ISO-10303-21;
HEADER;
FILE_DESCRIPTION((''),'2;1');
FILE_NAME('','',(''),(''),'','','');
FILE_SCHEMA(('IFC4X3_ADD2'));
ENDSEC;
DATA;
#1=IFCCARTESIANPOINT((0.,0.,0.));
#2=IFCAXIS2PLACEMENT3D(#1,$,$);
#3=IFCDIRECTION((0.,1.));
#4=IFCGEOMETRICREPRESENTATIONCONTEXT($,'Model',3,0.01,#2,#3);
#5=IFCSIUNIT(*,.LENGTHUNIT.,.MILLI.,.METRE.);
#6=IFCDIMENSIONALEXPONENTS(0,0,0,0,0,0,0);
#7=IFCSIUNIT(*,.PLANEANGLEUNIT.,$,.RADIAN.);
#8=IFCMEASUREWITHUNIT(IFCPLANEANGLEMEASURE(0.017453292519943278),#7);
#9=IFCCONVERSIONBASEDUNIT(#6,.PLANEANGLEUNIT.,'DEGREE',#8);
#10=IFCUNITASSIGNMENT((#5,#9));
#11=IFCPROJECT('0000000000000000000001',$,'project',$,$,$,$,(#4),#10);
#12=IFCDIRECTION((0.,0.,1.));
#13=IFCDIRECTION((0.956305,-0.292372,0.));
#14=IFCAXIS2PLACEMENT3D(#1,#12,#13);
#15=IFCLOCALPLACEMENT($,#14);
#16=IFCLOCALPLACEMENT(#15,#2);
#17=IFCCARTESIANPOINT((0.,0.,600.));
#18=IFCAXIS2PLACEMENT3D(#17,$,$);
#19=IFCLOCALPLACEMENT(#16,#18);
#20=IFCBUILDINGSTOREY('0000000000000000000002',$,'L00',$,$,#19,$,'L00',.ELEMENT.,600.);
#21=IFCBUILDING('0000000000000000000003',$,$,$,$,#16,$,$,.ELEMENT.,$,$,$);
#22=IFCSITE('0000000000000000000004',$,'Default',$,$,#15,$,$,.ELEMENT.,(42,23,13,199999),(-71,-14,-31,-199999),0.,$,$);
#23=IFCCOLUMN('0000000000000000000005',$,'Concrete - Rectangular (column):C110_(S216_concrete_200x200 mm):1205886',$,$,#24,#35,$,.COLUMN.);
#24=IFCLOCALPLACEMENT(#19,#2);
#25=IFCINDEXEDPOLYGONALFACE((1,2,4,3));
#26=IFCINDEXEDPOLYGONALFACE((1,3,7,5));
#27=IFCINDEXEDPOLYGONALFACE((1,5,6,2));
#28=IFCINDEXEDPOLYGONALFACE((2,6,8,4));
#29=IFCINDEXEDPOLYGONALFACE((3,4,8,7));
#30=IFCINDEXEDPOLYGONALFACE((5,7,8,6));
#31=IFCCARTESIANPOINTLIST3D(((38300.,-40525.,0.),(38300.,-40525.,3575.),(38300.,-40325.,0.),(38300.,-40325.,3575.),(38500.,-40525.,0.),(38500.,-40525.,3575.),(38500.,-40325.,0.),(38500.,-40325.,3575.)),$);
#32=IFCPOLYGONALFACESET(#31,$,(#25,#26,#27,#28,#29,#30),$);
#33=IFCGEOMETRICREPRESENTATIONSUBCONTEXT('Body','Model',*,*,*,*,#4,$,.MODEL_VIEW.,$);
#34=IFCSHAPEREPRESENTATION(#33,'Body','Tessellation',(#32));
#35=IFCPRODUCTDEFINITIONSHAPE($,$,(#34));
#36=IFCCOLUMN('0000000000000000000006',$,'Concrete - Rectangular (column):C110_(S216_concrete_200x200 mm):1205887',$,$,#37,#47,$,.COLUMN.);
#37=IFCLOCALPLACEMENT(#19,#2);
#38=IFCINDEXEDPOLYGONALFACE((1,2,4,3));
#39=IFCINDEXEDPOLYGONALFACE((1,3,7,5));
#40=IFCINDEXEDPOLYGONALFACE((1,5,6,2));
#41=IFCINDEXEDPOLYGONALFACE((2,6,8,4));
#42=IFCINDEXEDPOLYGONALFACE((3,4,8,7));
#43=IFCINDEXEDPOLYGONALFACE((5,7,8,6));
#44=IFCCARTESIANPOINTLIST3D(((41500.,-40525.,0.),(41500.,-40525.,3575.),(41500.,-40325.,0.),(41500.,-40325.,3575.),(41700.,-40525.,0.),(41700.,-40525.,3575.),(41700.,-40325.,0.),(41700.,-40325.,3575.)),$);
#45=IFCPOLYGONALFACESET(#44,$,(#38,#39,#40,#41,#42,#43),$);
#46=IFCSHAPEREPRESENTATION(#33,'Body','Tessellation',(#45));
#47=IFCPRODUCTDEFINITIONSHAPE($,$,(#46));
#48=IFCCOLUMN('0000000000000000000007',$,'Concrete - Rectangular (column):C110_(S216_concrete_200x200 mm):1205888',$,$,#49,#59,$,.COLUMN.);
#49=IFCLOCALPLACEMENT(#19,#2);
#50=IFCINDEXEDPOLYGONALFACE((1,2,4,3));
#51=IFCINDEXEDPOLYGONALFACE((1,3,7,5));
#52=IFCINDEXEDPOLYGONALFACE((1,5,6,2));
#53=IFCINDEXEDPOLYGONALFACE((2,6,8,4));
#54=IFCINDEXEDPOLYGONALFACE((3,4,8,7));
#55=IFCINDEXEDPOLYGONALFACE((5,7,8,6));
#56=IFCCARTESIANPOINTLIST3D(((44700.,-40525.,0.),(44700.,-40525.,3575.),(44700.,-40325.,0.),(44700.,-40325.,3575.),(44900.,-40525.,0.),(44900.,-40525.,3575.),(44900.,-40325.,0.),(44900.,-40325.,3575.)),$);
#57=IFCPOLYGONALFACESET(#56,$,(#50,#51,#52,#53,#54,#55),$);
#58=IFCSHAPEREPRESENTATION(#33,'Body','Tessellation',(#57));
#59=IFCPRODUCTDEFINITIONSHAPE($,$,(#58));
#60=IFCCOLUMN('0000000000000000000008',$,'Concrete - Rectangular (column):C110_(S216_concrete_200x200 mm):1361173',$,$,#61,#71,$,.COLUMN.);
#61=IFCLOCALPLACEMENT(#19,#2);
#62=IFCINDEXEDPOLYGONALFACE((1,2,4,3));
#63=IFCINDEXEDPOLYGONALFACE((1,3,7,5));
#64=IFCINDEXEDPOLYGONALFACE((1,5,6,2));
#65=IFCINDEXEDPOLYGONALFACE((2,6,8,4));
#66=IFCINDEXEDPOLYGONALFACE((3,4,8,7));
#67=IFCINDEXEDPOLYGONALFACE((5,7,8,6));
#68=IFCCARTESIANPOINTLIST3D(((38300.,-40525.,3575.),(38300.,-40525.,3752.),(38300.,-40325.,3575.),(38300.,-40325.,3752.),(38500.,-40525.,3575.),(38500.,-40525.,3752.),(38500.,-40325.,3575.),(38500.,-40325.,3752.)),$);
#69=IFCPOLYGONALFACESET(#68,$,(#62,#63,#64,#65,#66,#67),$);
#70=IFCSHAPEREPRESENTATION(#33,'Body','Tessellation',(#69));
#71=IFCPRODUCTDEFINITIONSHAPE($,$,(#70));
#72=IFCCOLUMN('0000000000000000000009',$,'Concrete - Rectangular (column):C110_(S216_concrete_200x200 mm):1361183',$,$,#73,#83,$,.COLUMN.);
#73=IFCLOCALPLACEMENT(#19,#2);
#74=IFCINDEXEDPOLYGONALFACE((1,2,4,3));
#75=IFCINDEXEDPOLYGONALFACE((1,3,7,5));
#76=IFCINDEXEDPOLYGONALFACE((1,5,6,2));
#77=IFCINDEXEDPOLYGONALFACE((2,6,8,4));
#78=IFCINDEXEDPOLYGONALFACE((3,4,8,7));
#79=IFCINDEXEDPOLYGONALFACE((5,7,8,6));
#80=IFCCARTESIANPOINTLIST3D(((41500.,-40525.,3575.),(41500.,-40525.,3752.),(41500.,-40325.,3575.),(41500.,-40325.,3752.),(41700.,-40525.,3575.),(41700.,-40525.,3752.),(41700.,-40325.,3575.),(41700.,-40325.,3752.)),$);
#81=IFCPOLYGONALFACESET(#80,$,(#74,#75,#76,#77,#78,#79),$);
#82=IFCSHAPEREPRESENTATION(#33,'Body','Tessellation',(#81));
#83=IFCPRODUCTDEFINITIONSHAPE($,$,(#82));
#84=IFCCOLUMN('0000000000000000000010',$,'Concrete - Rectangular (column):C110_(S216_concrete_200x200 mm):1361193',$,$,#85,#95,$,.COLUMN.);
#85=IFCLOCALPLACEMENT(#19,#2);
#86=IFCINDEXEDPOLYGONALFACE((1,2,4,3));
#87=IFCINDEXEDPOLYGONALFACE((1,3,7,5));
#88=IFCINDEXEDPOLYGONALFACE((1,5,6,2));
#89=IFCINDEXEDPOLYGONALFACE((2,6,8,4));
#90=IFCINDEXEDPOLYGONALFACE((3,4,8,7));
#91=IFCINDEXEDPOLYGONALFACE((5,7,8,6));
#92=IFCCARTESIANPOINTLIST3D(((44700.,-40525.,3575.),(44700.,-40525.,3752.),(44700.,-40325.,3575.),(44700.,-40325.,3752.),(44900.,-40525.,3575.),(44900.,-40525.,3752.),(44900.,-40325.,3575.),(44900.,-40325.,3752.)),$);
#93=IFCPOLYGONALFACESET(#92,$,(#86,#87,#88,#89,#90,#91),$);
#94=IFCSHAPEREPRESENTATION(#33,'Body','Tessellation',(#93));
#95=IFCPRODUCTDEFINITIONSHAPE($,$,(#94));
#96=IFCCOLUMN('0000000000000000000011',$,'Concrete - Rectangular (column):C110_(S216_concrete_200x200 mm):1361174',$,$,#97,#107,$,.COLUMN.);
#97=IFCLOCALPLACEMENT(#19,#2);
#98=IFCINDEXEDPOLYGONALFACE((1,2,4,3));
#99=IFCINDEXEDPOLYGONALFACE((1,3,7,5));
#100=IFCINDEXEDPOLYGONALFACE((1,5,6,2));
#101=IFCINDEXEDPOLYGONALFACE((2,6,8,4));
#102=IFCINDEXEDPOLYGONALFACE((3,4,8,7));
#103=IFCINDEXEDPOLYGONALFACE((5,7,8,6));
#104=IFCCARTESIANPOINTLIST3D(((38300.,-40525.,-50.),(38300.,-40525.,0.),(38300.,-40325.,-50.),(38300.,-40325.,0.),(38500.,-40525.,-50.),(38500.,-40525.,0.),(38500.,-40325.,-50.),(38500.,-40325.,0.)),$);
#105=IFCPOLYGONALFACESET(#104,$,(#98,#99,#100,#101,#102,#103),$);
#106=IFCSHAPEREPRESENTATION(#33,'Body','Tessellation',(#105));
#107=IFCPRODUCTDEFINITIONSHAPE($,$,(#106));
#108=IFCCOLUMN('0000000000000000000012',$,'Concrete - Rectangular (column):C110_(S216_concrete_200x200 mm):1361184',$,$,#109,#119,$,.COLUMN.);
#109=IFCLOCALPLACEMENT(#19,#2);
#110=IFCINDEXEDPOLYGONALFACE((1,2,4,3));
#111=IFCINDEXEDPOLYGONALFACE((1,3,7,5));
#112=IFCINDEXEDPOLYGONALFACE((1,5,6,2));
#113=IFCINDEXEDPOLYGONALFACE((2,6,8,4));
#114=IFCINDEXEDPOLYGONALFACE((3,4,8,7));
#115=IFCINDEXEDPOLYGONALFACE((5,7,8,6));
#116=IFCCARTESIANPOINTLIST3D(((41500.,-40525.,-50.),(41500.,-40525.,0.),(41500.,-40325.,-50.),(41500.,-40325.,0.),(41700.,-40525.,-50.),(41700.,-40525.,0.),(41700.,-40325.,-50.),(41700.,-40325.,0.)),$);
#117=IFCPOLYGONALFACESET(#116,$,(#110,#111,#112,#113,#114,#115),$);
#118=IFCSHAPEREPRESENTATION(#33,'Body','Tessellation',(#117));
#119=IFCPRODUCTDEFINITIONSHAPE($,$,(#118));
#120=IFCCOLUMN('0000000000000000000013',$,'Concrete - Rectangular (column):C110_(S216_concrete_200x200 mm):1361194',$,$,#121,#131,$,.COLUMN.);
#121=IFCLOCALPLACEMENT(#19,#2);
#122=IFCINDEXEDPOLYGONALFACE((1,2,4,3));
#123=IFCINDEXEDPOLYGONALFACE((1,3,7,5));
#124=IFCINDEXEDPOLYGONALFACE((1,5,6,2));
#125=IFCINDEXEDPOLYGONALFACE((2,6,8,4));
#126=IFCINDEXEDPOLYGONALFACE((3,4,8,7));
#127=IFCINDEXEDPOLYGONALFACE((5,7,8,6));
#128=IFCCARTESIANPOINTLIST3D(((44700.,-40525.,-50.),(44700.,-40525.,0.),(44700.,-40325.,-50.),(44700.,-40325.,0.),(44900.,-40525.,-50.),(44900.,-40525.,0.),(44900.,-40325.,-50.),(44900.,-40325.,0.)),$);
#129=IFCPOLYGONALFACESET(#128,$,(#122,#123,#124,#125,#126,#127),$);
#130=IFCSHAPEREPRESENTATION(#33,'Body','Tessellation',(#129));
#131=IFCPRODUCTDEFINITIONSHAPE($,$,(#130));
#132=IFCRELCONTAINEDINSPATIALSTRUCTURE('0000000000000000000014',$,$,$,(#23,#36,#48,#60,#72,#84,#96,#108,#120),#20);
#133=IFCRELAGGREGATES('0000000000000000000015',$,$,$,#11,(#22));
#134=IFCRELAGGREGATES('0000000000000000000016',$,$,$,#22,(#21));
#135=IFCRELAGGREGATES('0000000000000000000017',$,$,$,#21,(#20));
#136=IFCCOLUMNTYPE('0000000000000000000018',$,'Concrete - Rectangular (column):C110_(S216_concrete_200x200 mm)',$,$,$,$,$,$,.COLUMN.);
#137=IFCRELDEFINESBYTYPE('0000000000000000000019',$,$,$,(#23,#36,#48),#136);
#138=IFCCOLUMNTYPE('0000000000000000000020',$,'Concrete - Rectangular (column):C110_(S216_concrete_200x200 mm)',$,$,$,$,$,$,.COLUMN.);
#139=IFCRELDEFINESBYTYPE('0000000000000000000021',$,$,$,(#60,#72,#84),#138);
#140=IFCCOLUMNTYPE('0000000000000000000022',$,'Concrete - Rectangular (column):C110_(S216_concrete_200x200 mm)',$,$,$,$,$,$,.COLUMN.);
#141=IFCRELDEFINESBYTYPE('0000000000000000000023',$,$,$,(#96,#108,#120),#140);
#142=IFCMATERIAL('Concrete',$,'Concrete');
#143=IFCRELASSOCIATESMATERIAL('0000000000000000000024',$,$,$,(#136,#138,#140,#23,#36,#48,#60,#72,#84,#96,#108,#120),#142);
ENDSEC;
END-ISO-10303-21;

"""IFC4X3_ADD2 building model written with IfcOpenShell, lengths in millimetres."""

from ifc_helpers import new_model, entity, si_unit, converted_unit, direction, frame, origin, origin_2d_with_axis, place, context, subcontext, project, spatial, rectangle, extrude, source, transform, mapped, material, material_profile, profile_set, profile_usage, type_object, type_shapes, element, save


model = new_model("IFC4X3_ADD2")

# Units and contexts
model_context = context("Model", 3, precision=0.01, world=origin(), true_north=direction((0.0, 1.0)))
body_context = subcontext(model_context, "Body", "Model", "MODEL_VIEW")
ifc_project = project(units=[si_unit("LENGTHUNIT", "METRE", prefix="MILLI"), converted_unit("PLANEANGLEUNIT", "DEGREE", entity("IfcPlaneAngleMeasure", 0.017453292519943278), si_unit("PLANEANGLEUNIT", "RADIAN"), dimensions=[0, 0, 0, 0, 0, 0, 0])], contexts=[model_context])

# Site, building, storey
site_placement = place(None, frame((0.0, 0.0, 0.0), z_axis=(0.0, 0.0, 1.0), x_axis=(0.956305, -0.292372, 0.0)))
site = spatial("IfcSite", under=ifc_project, at=site_placement, Name="Default", CompositionType="ELEMENT", RefLatitude=(42, 23, 13, 199999), RefLongitude=(-71, -14, -31, -199999), RefElevation=0.0)
building_placement = place(site_placement, origin())
building = spatial("IfcBuilding", under=site, at=building_placement, CompositionType="ELEMENT")
storey_placement = place(building_placement, frame((0.0, 0.0, 600.0)))
storey = spatial("IfcBuildingStorey", under=building, at=storey_placement, Name="L00", LongName="L00", CompositionType="ELEMENT", Elevation=600.0)

# Columns
ifc_material_1 = material(Name="Concrete", Category="Concrete")
ifc_material_profile_1 = material_profile(ifc_material_1, rectangle(XDim=200.0, YDim=200.0, at=origin_2d_with_axis()), Name="C110_(S216_concrete_200x200 mm)")
ifc_profile_set_1 = profile_set([ifc_material_profile_1], Name="C110_(S216_concrete_200x200 mm)")
ifc_profile_usage_1 = profile_usage(ifc_profile_set_1)
column_type_1 = type_object("IfcColumnType", Name="Concrete - Rectangular (column):C110_(S216_concrete_200x200 mm)", PredefinedType="COLUMN", material=ifc_profile_set_1)
shared_shape_1 = source(origin(), body_context, "Body", "SweptSolid", [
    extrude(rectangle(XDim=200.0, YDim=200.0, at=origin_2d_with_axis()), frame((0.0, 0.0, 600.0), z_axis=(0.0, 0.0, 1.0), x_axis=(-1.0, 0.0, 0.0)), (0.0, 0.0, 1.0), 3575.0),
])
type_shapes(column_type_1, [shared_shape_1])
for number, where, name in (
    (1, (38400.0, -40425.0, -600.0), "Concrete - Rectangular (column):C110_(S216_concrete_200x200 mm):1205886"),
    (2, (41600.0, -40425.0, -600.0), "Concrete - Rectangular (column):C110_(S216_concrete_200x200 mm):1205887"),
    (3, (44800.0, -40425.0, -600.0), "Concrete - Rectangular (column):C110_(S216_concrete_200x200 mm):1205888"),
):
    element("IfcColumn", number, at=place(storey_placement, frame(where)), inside=storey, type_object=column_type_1, material=ifc_profile_usage_1, Name=name, PredefinedType="COLUMN", context=body_context, shape_type="MappedRepresentation", body=[
        mapped(shared_shape_1, transform((0.0, 0.0, 0.0), scale=1.0)),
    ])
column_type_2 = type_object("IfcColumnType", Name="Concrete - Rectangular (column):C110_(S216_concrete_200x200 mm)", PredefinedType="COLUMN", material=ifc_profile_set_1)
shared_shape_2 = source(origin(), body_context, "Body", "SweptSolid", [
    extrude(rectangle(XDim=200.0, YDim=200.0, at=origin_2d_with_axis()), frame((0.0, 0.0, 4175.0), z_axis=(0.0, 0.0, 1.0), x_axis=(-1.0, 0.0, 0.0)), (0.0, 0.0, 1.0), 177.0),
])
type_shapes(column_type_2, [shared_shape_2])
for number, where, name in (
    (4, (38400.0, -40425.0, -600.0), "Concrete - Rectangular (column):C110_(S216_concrete_200x200 mm):1361173"),
    (5, (41600.0, -40425.0, -600.0), "Concrete - Rectangular (column):C110_(S216_concrete_200x200 mm):1361183"),
    (6, (44800.0, -40425.0, -600.0), "Concrete - Rectangular (column):C110_(S216_concrete_200x200 mm):1361193"),
):
    element("IfcColumn", number, at=place(storey_placement, frame(where)), inside=storey, type_object=column_type_2, material=ifc_profile_usage_1, Name=name, PredefinedType="COLUMN", context=body_context, shape_type="MappedRepresentation", body=[
        mapped(shared_shape_2, transform((0.0, 0.0, 0.0), scale=1.0)),
    ])
column_type_3 = type_object("IfcColumnType", Name="Concrete - Rectangular (column):C110_(S216_concrete_200x200 mm)", PredefinedType="COLUMN", material=ifc_profile_set_1)
shared_shape_3 = source(origin(), body_context, "Body", "SweptSolid", [
    extrude(rectangle(XDim=200.0, YDim=200.0, at=origin_2d_with_axis()), frame((0.0, 0.0, 550.0), z_axis=(0.0, 0.0, 1.0), x_axis=(-1.0, 0.0, 0.0)), (0.0, 0.0, 1.0), 50.0),
])
type_shapes(column_type_3, [shared_shape_3])
for number, where, name in (
    (7, (38400.0, -40425.0, -600.0), "Concrete - Rectangular (column):C110_(S216_concrete_200x200 mm):1361174"),
    (8, (41600.0, -40425.0, -600.0), "Concrete - Rectangular (column):C110_(S216_concrete_200x200 mm):1361184"),
    (9, (44800.0, -40425.0, -600.0), "Concrete - Rectangular (column):C110_(S216_concrete_200x200 mm):1361194"),
):
    element("IfcColumn", number, at=place(storey_placement, frame(where)), inside=storey, type_object=column_type_3, material=ifc_profile_usage_1, Name=name, PredefinedType="COLUMN", context=body_context, shape_type="MappedRepresentation", body=[
        mapped(shared_shape_3, transform((0.0, 0.0, 0.0), scale=1.0)),
    ])

save(model, "model.ifc")
